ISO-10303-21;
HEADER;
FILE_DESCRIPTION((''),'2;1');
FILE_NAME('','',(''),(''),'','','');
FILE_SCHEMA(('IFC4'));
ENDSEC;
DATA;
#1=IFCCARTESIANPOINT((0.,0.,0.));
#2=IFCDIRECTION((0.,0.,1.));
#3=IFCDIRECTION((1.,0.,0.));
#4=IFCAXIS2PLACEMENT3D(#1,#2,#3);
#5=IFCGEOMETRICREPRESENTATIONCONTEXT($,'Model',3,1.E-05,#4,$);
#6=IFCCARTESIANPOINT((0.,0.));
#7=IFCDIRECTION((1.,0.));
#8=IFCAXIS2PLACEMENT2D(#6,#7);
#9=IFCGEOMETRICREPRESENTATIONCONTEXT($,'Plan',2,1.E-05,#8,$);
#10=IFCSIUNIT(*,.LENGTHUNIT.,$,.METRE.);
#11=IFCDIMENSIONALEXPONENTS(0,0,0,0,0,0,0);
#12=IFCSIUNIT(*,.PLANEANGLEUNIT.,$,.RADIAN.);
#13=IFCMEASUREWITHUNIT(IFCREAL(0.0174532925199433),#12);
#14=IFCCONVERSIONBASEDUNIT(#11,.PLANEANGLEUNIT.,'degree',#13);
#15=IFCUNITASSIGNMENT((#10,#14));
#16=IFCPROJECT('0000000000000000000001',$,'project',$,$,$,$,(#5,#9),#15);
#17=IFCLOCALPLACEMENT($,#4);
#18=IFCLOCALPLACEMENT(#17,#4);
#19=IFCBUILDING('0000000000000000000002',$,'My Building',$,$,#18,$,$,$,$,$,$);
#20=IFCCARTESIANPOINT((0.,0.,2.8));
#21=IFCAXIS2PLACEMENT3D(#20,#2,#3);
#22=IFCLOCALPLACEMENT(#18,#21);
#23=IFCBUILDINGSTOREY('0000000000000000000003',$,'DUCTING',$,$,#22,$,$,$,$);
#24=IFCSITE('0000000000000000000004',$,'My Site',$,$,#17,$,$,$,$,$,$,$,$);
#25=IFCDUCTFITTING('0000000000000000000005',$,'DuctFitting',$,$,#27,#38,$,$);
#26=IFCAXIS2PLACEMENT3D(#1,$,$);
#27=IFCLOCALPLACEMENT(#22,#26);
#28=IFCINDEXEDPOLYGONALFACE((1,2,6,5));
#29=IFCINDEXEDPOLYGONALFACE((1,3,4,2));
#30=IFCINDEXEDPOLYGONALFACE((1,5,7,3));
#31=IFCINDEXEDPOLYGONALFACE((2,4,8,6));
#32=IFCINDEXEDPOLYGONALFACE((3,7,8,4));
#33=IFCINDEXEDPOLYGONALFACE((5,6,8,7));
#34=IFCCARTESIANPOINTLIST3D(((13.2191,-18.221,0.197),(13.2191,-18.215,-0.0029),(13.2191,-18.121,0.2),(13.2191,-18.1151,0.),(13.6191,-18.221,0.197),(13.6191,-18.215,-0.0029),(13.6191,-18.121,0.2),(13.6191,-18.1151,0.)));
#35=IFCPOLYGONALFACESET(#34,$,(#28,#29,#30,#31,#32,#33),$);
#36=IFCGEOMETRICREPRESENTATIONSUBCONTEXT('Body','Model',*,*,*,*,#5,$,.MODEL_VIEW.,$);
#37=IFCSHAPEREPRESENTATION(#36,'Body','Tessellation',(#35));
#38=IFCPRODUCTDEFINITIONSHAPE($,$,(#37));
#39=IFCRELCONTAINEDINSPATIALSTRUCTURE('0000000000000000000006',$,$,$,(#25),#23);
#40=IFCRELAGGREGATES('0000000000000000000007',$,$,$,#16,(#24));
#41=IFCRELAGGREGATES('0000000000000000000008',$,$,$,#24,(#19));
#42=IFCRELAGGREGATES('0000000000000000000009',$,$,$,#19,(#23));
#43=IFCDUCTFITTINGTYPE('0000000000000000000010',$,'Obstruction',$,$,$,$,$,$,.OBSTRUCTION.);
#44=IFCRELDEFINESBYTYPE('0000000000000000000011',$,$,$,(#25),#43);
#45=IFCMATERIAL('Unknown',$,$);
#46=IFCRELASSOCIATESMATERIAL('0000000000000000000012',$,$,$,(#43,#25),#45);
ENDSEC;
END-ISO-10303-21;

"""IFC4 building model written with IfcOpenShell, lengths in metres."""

from ifc_helpers import new_model, entity, si_unit, converted_unit, frame, origin_with_axes, origin_2d_with_axis, place, context, subcontext, project, spatial, rectangle, extrude, material, material_profile, profile_set, profile_usage, type_object, element, save


model = new_model("IFC4")

# Units and contexts
model_context = context("Model", 3, precision=1e-05, world=origin_with_axes())
plan_context = context("Plan", 2, precision=1e-05, world=origin_2d_with_axis())
body_context = subcontext(model_context, "Body", "Model", "MODEL_VIEW")
ifc_project = project(units=[si_unit("LENGTHUNIT", "METRE"), converted_unit("PLANEANGLEUNIT", "degree", entity("IfcReal", 0.0174532925199433), si_unit("PLANEANGLEUNIT", "RADIAN"), dimensions=[0, 0, 0, 0, 0, 0, 0])], contexts=[model_context, plan_context])

# Site, building, storey
site_placement = place(None, origin_with_axes())
site = spatial("IfcSite", under=ifc_project, at=site_placement, Name="My Site")
building_placement = place(site_placement, origin_with_axes())
building = spatial("IfcBuilding", under=site, at=building_placement, Name="My Building")
storey_placement = place(building_placement, frame((0.0, 0.0, 2.8), z_axis=(0.0, 0.0, 1.0), x_axis=(1.0, 0.0, 0.0)))
storey = spatial("IfcBuildingStorey", under=building, at=storey_placement, Name="DUCTING")

# Shared definitions
ifc_material = material(Name="Unknown")

# Duct fitting
ifc_material_profile_1 = material_profile(ifc_material, rectangle(XDim=0.4, YDim=0.2))
ifc_profile_set_1 = profile_set([ifc_material_profile_1])
duct_fitting_type_1 = type_object("IfcDuctFittingType", Name="Obstruction", PredefinedType="OBSTRUCTION", material=ifc_profile_set_1)
ifc_profile_usage_1 = profile_usage(ifc_profile_set_1, cardinal=5)
duct_fitting_1_placement = place(storey_placement, frame((13.4191, -18.118, 0.1), z_axis=(-0.000001, -0.999553, -0.029908), x_axis=(1.0, -0.000001, 0.0)))
element("IfcDuctFitting", 1, at=duct_fitting_1_placement, inside=storey, type_object=duct_fitting_type_1, material=ifc_profile_usage_1, Name="DuctFitting", context=body_context, shape_type="SweptSolid", body=[
    extrude(rectangle(XDim=0.4, YDim=0.2), origin_with_axes(), (0.0, 0.0, 1.0), 0.1),
])

save(model, "model.ifc")
